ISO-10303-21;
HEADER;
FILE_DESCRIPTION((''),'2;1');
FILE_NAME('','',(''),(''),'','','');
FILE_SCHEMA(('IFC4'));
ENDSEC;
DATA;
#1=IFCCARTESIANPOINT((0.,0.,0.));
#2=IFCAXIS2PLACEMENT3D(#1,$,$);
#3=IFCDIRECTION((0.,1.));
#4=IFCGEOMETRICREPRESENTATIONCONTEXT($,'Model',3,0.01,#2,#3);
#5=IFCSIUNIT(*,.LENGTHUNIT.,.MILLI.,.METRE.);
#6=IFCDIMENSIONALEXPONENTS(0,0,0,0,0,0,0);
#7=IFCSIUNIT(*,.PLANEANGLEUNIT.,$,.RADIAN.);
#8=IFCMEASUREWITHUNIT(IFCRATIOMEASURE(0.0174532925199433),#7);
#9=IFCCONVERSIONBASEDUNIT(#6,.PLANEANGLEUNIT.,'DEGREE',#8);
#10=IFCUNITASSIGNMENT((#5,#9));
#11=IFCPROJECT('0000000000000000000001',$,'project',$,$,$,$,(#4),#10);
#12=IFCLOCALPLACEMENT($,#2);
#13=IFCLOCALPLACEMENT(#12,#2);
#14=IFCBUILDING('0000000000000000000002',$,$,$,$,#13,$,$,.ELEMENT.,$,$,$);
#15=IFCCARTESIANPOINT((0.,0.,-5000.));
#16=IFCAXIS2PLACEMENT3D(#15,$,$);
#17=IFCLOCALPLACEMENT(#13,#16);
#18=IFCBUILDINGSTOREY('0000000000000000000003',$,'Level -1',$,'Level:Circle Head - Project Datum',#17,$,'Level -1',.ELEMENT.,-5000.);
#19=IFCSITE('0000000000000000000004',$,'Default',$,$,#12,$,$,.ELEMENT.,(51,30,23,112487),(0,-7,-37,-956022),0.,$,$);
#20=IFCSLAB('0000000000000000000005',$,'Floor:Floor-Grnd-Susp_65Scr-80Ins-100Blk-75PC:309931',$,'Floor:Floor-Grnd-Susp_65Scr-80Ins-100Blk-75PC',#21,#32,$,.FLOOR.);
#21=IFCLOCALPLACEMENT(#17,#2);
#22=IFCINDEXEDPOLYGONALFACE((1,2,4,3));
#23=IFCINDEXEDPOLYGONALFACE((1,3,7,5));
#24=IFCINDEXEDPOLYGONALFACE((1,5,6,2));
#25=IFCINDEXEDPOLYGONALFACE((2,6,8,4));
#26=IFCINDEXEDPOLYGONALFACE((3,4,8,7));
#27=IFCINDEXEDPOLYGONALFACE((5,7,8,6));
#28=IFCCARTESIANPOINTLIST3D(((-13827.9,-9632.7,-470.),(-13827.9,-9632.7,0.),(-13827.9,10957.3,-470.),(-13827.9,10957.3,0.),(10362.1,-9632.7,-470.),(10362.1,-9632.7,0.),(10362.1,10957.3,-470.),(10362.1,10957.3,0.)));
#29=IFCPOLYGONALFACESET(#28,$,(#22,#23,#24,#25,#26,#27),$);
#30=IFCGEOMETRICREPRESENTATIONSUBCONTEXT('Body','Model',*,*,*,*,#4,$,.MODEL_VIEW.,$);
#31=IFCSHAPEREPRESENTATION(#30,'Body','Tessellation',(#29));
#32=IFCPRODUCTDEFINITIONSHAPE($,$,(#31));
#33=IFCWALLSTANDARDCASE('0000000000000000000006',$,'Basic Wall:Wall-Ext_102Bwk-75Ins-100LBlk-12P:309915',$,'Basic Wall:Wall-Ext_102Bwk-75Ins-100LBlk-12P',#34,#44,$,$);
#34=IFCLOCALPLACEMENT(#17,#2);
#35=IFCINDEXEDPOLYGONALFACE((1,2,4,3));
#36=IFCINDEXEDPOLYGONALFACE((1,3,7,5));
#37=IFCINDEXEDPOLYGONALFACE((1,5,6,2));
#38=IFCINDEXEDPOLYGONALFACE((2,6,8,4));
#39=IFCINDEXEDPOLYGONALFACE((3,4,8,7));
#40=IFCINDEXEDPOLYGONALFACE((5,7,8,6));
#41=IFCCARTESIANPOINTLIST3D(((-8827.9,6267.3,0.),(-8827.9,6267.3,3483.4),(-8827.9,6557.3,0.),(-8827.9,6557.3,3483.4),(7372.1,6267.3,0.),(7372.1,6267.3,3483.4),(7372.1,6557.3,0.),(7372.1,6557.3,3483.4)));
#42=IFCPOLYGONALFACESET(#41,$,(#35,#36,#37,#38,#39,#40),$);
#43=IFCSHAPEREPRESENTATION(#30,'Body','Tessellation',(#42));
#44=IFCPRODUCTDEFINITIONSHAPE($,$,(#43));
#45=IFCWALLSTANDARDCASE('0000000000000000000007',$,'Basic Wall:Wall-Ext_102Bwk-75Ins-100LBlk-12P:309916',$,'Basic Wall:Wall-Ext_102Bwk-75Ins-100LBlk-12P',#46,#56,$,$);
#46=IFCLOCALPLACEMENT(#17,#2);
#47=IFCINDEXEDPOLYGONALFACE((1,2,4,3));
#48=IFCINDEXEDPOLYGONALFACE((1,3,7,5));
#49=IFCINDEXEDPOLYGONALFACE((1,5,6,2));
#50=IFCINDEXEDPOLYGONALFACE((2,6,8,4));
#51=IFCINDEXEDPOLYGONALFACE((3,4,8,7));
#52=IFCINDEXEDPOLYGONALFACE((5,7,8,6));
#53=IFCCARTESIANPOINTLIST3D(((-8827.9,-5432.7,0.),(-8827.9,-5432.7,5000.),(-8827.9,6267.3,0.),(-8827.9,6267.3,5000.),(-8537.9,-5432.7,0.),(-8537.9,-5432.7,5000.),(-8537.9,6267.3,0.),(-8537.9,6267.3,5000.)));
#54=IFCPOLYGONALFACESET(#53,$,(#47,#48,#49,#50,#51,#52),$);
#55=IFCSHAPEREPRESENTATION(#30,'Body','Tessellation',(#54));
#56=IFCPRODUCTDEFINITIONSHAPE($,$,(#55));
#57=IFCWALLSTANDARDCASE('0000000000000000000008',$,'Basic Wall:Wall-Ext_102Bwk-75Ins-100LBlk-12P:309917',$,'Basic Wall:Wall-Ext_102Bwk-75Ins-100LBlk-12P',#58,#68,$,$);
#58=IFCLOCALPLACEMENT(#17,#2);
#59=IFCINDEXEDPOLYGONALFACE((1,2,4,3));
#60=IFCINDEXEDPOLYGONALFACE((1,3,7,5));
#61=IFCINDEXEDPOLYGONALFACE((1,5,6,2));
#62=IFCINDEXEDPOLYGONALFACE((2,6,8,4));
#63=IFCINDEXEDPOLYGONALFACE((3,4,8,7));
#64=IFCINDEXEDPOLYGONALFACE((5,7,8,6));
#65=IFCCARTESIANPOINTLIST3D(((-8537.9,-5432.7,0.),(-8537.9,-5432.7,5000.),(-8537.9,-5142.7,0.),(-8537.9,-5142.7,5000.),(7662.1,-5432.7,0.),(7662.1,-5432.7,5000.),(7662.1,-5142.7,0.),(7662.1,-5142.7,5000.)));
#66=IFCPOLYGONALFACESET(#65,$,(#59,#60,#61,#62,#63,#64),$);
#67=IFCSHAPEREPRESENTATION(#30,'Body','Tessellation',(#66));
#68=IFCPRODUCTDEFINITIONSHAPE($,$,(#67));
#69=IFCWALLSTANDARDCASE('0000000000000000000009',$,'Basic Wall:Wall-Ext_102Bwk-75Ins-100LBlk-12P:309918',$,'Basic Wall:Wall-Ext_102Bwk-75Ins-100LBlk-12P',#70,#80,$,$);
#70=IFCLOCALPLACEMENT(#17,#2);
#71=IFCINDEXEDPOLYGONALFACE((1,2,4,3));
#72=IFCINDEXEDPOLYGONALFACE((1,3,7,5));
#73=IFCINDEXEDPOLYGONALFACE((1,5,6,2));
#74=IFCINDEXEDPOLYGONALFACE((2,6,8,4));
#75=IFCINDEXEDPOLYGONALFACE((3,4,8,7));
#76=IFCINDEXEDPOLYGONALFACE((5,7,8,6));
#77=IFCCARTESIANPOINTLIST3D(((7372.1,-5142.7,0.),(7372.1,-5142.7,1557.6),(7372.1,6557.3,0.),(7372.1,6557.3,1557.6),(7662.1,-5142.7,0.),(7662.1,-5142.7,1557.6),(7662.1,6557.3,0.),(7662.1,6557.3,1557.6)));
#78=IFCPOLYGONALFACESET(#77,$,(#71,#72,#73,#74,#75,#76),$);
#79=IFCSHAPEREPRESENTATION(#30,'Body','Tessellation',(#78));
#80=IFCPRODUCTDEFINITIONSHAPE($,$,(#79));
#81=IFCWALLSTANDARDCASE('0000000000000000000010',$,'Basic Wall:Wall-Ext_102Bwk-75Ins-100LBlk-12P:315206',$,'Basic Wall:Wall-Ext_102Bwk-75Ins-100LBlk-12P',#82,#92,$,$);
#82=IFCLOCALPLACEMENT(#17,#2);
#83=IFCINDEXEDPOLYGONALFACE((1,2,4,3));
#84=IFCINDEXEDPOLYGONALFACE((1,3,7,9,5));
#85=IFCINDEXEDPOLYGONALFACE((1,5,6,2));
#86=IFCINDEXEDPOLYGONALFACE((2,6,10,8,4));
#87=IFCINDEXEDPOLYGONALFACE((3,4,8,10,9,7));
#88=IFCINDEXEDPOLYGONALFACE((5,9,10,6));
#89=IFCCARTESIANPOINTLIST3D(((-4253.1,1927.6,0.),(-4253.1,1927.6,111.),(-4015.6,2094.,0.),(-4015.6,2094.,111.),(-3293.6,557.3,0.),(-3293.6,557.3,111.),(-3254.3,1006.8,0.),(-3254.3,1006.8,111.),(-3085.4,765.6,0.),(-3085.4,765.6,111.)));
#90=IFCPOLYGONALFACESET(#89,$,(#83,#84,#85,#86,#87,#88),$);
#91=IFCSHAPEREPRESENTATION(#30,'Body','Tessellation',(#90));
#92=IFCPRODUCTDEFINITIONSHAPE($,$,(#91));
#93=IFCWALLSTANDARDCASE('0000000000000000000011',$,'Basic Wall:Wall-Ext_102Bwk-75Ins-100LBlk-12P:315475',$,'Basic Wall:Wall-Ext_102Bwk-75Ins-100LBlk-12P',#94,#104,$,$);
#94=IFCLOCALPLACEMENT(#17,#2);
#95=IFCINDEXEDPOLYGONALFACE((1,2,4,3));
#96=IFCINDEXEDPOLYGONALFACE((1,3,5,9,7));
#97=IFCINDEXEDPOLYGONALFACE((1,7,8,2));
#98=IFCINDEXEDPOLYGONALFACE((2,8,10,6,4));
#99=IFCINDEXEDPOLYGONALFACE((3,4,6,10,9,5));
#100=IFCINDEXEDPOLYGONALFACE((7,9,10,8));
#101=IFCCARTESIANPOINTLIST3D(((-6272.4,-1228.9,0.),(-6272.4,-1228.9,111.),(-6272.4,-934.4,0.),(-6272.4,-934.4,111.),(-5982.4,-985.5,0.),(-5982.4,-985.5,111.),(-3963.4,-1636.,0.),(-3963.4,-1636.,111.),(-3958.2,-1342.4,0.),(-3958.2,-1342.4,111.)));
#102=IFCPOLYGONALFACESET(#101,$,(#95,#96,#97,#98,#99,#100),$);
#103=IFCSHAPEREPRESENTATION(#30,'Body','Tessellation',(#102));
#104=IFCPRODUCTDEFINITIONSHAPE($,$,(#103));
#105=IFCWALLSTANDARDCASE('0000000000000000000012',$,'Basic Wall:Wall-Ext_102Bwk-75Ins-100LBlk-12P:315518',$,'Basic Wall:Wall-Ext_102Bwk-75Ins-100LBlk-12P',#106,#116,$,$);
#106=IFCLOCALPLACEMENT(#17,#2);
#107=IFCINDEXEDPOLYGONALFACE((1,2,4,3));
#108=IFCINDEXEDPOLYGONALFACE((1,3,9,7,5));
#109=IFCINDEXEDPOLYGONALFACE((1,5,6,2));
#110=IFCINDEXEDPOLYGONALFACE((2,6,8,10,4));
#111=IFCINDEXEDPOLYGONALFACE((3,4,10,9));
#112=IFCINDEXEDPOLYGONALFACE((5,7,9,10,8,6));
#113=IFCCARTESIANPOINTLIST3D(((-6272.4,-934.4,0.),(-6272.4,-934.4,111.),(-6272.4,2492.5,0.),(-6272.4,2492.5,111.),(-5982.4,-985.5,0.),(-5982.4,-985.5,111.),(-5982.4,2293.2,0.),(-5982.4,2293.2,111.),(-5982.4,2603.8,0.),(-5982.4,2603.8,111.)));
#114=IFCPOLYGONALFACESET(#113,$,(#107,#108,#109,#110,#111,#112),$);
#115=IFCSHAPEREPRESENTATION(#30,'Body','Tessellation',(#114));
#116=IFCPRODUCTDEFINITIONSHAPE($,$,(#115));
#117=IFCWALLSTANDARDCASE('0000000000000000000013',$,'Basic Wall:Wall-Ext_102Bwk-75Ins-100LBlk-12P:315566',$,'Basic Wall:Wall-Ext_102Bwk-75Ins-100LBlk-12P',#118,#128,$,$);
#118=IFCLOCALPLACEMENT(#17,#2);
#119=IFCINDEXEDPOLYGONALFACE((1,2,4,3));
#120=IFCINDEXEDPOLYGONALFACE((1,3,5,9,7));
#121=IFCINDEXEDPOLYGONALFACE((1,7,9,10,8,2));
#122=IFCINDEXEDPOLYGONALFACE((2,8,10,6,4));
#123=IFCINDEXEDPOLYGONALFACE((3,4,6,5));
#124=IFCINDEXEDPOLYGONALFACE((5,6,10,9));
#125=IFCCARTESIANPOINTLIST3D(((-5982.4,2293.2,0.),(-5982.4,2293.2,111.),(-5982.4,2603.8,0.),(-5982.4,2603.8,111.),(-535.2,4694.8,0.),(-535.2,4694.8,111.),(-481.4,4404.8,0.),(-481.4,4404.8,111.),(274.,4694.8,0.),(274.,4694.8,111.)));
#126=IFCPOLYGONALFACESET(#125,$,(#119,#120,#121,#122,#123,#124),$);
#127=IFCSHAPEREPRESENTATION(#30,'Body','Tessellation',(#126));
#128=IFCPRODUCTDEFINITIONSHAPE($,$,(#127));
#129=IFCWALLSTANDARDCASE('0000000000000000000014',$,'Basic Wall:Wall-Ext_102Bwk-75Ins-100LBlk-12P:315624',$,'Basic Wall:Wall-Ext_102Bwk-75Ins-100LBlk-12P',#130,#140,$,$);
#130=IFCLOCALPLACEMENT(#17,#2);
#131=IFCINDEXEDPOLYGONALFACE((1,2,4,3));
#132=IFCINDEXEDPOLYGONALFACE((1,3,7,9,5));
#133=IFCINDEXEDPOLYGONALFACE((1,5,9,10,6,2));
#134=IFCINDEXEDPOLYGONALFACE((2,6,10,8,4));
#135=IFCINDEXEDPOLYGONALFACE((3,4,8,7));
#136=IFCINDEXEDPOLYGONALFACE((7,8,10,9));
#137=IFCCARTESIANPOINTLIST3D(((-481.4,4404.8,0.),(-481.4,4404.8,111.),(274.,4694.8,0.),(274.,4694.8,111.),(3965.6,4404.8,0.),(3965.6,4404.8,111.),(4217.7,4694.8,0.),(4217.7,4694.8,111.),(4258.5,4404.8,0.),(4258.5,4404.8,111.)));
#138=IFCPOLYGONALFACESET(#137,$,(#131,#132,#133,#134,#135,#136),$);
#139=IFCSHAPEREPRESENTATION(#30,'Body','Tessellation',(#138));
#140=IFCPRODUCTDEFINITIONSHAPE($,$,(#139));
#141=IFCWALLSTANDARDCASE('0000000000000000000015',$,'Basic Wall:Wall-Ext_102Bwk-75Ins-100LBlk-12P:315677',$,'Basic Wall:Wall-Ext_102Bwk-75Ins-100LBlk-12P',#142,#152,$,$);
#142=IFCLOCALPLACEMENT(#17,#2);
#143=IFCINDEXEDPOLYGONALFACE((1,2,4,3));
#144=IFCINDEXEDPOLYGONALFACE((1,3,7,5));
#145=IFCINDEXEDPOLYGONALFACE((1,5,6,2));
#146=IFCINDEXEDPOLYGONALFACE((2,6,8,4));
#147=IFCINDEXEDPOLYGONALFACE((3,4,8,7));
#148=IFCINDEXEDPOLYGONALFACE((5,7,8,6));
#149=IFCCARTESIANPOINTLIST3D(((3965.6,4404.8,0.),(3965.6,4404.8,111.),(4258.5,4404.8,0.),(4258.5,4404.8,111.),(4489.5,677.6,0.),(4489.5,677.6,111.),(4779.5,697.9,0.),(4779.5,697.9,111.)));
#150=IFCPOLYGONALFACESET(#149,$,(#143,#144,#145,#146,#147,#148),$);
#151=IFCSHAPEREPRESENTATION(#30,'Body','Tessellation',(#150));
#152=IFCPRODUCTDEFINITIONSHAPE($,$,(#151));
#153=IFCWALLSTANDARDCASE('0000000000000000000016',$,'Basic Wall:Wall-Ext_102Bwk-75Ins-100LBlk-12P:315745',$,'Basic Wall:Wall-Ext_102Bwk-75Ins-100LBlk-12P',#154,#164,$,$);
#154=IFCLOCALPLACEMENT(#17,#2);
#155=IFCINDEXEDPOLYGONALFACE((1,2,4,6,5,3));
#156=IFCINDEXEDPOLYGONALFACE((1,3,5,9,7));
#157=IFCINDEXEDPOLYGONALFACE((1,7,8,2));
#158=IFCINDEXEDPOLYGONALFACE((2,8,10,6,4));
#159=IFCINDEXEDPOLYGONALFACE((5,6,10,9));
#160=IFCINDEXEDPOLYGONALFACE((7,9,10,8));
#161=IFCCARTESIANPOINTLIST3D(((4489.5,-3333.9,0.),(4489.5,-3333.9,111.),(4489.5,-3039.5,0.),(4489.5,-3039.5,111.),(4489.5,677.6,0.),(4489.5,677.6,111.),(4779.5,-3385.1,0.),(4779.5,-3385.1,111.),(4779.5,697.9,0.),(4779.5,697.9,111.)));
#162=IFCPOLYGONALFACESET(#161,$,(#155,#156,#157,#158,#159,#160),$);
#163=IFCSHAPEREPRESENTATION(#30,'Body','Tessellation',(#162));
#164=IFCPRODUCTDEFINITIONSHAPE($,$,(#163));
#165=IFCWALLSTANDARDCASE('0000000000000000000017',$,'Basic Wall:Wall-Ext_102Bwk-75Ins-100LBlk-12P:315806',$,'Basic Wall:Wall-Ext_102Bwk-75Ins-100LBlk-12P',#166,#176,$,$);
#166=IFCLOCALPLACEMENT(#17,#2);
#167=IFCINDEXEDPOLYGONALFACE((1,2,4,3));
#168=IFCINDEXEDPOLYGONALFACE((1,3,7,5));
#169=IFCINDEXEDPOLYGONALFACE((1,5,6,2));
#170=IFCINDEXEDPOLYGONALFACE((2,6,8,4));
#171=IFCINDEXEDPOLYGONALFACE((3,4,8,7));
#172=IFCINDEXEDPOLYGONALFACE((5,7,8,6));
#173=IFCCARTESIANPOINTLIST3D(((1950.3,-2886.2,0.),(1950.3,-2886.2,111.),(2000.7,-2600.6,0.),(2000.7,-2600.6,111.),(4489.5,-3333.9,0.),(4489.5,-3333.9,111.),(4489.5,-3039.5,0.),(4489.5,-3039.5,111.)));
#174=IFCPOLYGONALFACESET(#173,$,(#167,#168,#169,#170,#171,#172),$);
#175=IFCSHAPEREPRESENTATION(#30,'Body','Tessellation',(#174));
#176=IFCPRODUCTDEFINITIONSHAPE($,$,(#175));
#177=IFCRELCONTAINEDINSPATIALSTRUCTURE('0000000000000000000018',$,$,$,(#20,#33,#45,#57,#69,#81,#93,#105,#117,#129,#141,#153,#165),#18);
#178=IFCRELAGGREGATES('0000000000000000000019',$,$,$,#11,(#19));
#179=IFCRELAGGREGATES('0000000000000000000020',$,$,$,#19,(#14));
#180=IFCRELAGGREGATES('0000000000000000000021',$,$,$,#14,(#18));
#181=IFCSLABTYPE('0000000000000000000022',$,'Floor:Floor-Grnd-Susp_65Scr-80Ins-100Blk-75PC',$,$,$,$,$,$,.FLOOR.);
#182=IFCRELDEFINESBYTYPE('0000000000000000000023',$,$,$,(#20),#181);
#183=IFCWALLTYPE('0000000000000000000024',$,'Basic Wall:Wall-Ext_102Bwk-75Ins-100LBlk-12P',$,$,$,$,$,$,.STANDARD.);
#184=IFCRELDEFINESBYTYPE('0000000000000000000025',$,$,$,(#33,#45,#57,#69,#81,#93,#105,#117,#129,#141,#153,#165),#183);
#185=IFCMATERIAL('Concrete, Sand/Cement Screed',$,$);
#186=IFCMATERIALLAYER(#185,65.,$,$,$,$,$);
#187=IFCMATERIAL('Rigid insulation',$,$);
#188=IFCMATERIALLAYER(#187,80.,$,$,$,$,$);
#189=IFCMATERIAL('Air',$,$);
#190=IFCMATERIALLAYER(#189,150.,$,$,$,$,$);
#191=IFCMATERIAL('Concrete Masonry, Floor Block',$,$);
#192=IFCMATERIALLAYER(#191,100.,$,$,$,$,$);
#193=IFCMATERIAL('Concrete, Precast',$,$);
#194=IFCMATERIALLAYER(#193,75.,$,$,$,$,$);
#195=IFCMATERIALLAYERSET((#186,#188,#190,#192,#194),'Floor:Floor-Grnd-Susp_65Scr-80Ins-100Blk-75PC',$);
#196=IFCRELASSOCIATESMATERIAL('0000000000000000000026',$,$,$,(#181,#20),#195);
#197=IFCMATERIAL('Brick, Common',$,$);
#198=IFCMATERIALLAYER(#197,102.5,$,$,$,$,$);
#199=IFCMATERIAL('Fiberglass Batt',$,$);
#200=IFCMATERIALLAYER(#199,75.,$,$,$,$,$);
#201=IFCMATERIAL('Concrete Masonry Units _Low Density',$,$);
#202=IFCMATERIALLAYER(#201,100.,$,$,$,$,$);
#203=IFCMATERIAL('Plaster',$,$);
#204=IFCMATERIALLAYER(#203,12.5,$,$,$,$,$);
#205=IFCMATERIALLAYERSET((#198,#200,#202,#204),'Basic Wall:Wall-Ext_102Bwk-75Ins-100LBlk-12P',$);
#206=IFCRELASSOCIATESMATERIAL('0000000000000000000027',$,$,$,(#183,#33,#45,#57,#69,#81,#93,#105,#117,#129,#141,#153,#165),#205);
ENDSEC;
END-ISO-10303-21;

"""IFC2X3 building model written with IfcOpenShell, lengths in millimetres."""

from ifc_helpers import new_model, entity, si_unit, converted_unit, direction, frame, frame_2d, origin, origin_2d_with_axis, place, context, subcontext, project, spatial, polyline, rectangle, outline, extrude, material, layer, layer_set, layer_usage, type_object, element, save


model = new_model("IFC2X3")

# Units and contexts
model_context = context("Model", 3, precision=0.01, world=origin(), true_north=direction((0.0, 1.0)))
body_context = subcontext(model_context, "Body", "Model", "MODEL_VIEW")
ifc_project = project(units=[si_unit("LENGTHUNIT", "METRE", prefix="MILLI"), converted_unit("PLANEANGLEUNIT", "DEGREE", entity("IfcRatioMeasure", 0.0174532925199433), si_unit("PLANEANGLEUNIT", "RADIAN"), dimensions=[0, 0, 0, 0, 0, 0, 0])], contexts=[model_context])

# Site, building, storey
site_placement = place(None, origin())
site = spatial("IfcSite", under=ifc_project, at=site_placement, Name="Default", CompositionType="ELEMENT", RefLatitude=(51, 30, 23, 112487), RefLongitude=(0, -7, -37, -956022), RefElevation=0.0)
building_placement = place(site_placement, origin())
building = spatial("IfcBuilding", under=site, at=building_placement, CompositionType="ELEMENT")
storey_placement = place(building_placement, frame((0.0, 0.0, -5000.0)))
storey = spatial("IfcBuildingStorey", under=building, at=storey_placement, Name="Level -1", ObjectType="Level:Circle Head - Project Datum", LongName="Level -1", CompositionType="ELEMENT", Elevation=-5000.0)

# Slab
ifc_material_1 = material(Name="Concrete, Sand/Cement Screed")
ifc_layer_1 = layer(ifc_material_1, 65.0)
ifc_material_2 = material(Name="Rigid insulation")
ifc_layer_2 = layer(ifc_material_2, 80.0)
ifc_material_3 = material(Name="Air")
ifc_layer_3 = layer(ifc_material_3, 150.0)
ifc_material_4 = material(Name="Concrete Masonry, Floor Block")
ifc_layer_4 = layer(ifc_material_4, 100.0)
ifc_material_5 = material(Name="Concrete, Precast")
ifc_layer_5 = layer(ifc_material_5, 75.0)
ifc_layer_set_1 = layer_set([ifc_layer_1, ifc_layer_2, ifc_layer_3, ifc_layer_4, ifc_layer_5], Name="Floor:Floor-Grnd-Susp_65Scr-80Ins-100Blk-75PC")
ifc_layer_usage_1 = layer_usage(ifc_layer_set_1, "AXIS3", "POSITIVE", 0.0)
slab_type = type_object("IfcSlabType", Name="Floor:Floor-Grnd-Susp_65Scr-80Ins-100Blk-75PC", PredefinedType="FLOOR", material=ifc_layer_set_1)
slab_placement = place(storey_placement, origin())
element("IfcSlab", 1, at=slab_placement, inside=storey, type_object=slab_type, material=ifc_layer_usage_1, Name="Floor:Floor-Grnd-Susp_65Scr-80Ins-100Blk-75PC:309931", ObjectType="Floor:Floor-Grnd-Susp_65Scr-80Ins-100Blk-75PC", PredefinedType="FLOOR", context=body_context, shape_type="SweptSolid", body=[
    extrude(rectangle(XDim=20590.0, YDim=24190.0, at=origin_2d_with_axis()), frame((-1732.9, 662.3, 0.0), z_axis=(0.0, 0.0, -1.0), x_axis=(0.0, 1.0, 0.0)), (0.0, 0.0, 1.0), 470.0),
])

# Walls
ifc_material_6 = material(Name="Brick, Common")
ifc_layer_6 = layer(ifc_material_6, 102.5)
ifc_material_7 = material(Name="Fiberglass Batt")
ifc_layer_7 = layer(ifc_material_7, 75.0)
ifc_material_8 = material(Name="Concrete Masonry Units _Low Density")
ifc_layer_8 = layer(ifc_material_8, 100.0)
ifc_material_9 = material(Name="Plaster")
ifc_layer_9 = layer(ifc_material_9, 12.5)
ifc_layer_set_2 = layer_set([ifc_layer_6, ifc_layer_7, ifc_layer_8, ifc_layer_9], Name="Basic Wall:Wall-Ext_102Bwk-75Ins-100LBlk-12P")
ifc_layer_usage_2 = layer_usage(ifc_layer_set_2, "AXIS2", "NEGATIVE", 145.0)
wall_type = type_object("IfcWallType", Name="Basic Wall:Wall-Ext_102Bwk-75Ins-100LBlk-12P", PredefinedType="STANDARD", material=ifc_layer_set_2)
wall_1_placement = place(storey_placement, frame((-8827.9, 6412.3, 0.0)))
element("IfcWallStandardCase", 2, at=wall_1_placement, inside=storey, type_object=wall_type, material=ifc_layer_usage_2, Name="Basic Wall:Wall-Ext_102Bwk-75Ins-100LBlk-12P:309915", ObjectType="Basic Wall:Wall-Ext_102Bwk-75Ins-100LBlk-12P", context=body_context, shape_type="SweptSolid", body=[
    extrude(rectangle(XDim=16200.0, YDim=290.0, at=frame_2d((8100.0, 0.0), x_axis=(-1.0, 0.0))), origin(), (0.0, 0.0, 1.0), 3483.4),
])
ifc_layer_usage_3 = layer_usage(ifc_layer_set_2, "AXIS2", "NEGATIVE", 145.0)
wall_2_placement = place(storey_placement, frame((-8682.9, -5432.7, 0.0), z_axis=(0.0, 0.0, 1.0), x_axis=(0.0, 1.0, 0.0)))
element("IfcWallStandardCase", 3, at=wall_2_placement, inside=storey, type_object=wall_type, material=ifc_layer_usage_3, Name="Basic Wall:Wall-Ext_102Bwk-75Ins-100LBlk-12P:309916", ObjectType="Basic Wall:Wall-Ext_102Bwk-75Ins-100LBlk-12P", context=body_context, shape_type="SweptSolid", body=[
    extrude(rectangle(XDim=11700.0, YDim=290.0, at=frame_2d((5850.0, 0.0), x_axis=(-1.0, 0.0))), origin(), (0.0, 0.0, 1.0), 5000.0),
])
ifc_layer_usage_4 = layer_usage(ifc_layer_set_2, "AXIS2", "NEGATIVE", 145.0)
wall_3_placement = place(storey_placement, frame((7662.1, -5287.7, 0.0), z_axis=(0.0, 0.0, 1.0), x_axis=(-1.0, 0.0, 0.0)))
element("IfcWallStandardCase", 4, at=wall_3_placement, inside=storey, type_object=wall_type, material=ifc_layer_usage_4, Name="Basic Wall:Wall-Ext_102Bwk-75Ins-100LBlk-12P:309917", ObjectType="Basic Wall:Wall-Ext_102Bwk-75Ins-100LBlk-12P", context=body_context, shape_type="SweptSolid", body=[
    extrude(rectangle(XDim=16200.0, YDim=290.0, at=frame_2d((8100.0, 0.0), x_axis=(-1.0, 0.0))), origin(), (0.0, 0.0, 1.0), 5000.0),
])
ifc_layer_usage_5 = layer_usage(ifc_layer_set_2, "AXIS2", "NEGATIVE", 145.0)
wall_4_placement = place(storey_placement, frame((7517.1, 6557.3, 0.0), z_axis=(0.0, 0.0, 1.0), x_axis=(0.0, -1.0, 0.0)))
element("IfcWallStandardCase", 5, at=wall_4_placement, inside=storey, type_object=wall_type, material=ifc_layer_usage_5, Name="Basic Wall:Wall-Ext_102Bwk-75Ins-100LBlk-12P:309918", ObjectType="Basic Wall:Wall-Ext_102Bwk-75Ins-100LBlk-12P", context=body_context, shape_type="SweptSolid", body=[
    extrude(rectangle(XDim=11700.0, YDim=290.0, at=frame_2d((5850.0, 0.0), x_axis=(-1.0, 0.0))), origin(), (0.0, 0.0, 1.0), 1557.6),
])
ifc_layer_usage_6 = layer_usage(ifc_layer_set_2, "AXIS2", "NEGATIVE", 145.0)
wall_5_placement = place(storey_placement, frame((-4134.4, 2010.8, 0.0), z_axis=(0.0, 0.0, 1.0), x_axis=(0.573576, -0.819152, 0.0)))
element("IfcWallStandardCase", 6, at=wall_5_placement, inside=storey, type_object=wall_type, material=ifc_layer_usage_6, Name="Basic Wall:Wall-Ext_102Bwk-75Ins-100LBlk-12P:315206", ObjectType="Basic Wall:Wall-Ext_102Bwk-75Ins-100LBlk-12P", context=body_context, shape_type="SweptSolid", body=[
    extrude(outline(polyline([(1672.8, -145.0), (1621.7, 145.0), (1327.2, 145.0), (0.0, 145.0), (0.0, -145.0), (1672.8, -145.0)])), origin(), (0.0, 0.0, 1.0), 111.0),
])
ifc_layer_usage_7 = layer_usage(ifc_layer_set_2, "AXIS2", "NEGATIVE", 145.0)
wall_6_placement = place(storey_placement, frame((-3938.2, -1493.2, 0.0), z_axis=(0.0, 0.0, 1.0), x_axis=(-0.984808, 0.173648, 0.0)))
element("IfcWallStandardCase", 7, at=wall_6_placement, inside=storey, type_object=wall_type, material=ifc_layer_usage_7, Name="Basic Wall:Wall-Ext_102Bwk-75Ins-100LBlk-12P:315475", ObjectType="Basic Wall:Wall-Ext_102Bwk-75Ins-100LBlk-12P", context=body_context, shape_type="SweptSolid", body=[
    extrude(outline(polyline([(2395.8, -145.0), (2344.6, 145.0), (0.0, 145.0), (45.9, -145.0), (2101.3, -145.0), (2395.8, -145.0)])), origin(), (0.0, 0.0, 1.0), 111.0),
])
ifc_layer_usage_8 = layer_usage(ifc_layer_set_2, "AXIS2", "NEGATIVE", 145.0)
wall_7_placement = place(storey_placement, frame((-6127.4, -985.5, 0.0), z_axis=(0.0, 0.0, 1.0), x_axis=(0.0, 1.0, 0.0)))
element("IfcWallStandardCase", 8, at=wall_7_placement, inside=storey, type_object=wall_type, material=ifc_layer_usage_8, Name="Basic Wall:Wall-Ext_102Bwk-75Ins-100LBlk-12P:315518", ObjectType="Basic Wall:Wall-Ext_102Bwk-75Ins-100LBlk-12P", context=body_context, shape_type="SweptSolid", body=[
    extrude(outline(polyline([(3589.3, -145.0), (3478.0, 145.0), (51.1, 145.0), (0.0, -145.0), (3278.7, -145.0), (3589.3, -145.0)])), origin(), (0.0, 0.0, 1.0), 111.0),
])
ifc_layer_usage_9 = layer_usage(ifc_layer_set_2, "AXIS2", "NEGATIVE", 145.0)
wall_8_placement = place(storey_placement, frame((-6034.3, 2428.5, 0.0), z_axis=(0.0, 0.0, 1.0), x_axis=(0.93358, 0.358368, 0.0)))
element("IfcWallStandardCase", 9, at=wall_8_placement, inside=storey, type_object=wall_type, material=ifc_layer_usage_9, Name="Basic Wall:Wall-Ext_102Bwk-75Ins-100LBlk-12P:315566", ObjectType="Basic Wall:Wall-Ext_102Bwk-75Ins-100LBlk-12P", context=body_context, shape_type="SweptSolid", body=[
    extrude(outline(polyline([(6701.5, -145.0), (5946.0, 145.0), (111.3, 145.0), (0.0, -145.0), (5892.3, -145.0), (6701.5, -145.0)])), origin(), (0.0, 0.0, 1.0), 111.0),
])
ifc_layer_usage_10 = layer_usage(ifc_layer_set_2, "AXIS2", "NEGATIVE", 145.0)
wall_9_placement = place(storey_placement, frame((-481.4, 4549.8, 0.0)))
element("IfcWallStandardCase", 10, at=wall_9_placement, inside=storey, type_object=wall_type, material=ifc_layer_usage_10, Name="Basic Wall:Wall-Ext_102Bwk-75Ins-100LBlk-12P:315624", ObjectType="Basic Wall:Wall-Ext_102Bwk-75Ins-100LBlk-12P", context=body_context, shape_type="SweptSolid", body=[
    extrude(outline(polyline([(4739.9, -145.0), (4699.2, 145.0), (755.5, 145.0), (0.0, -145.0), (4447.1, -145.0), (4739.9, -145.0)])), origin(), (0.0, 0.0, 1.0), 111.0),
])
ifc_layer_usage_11 = layer_usage(ifc_layer_set_2, "AXIS2", "NEGATIVE", 145.0)
wall_10_placement = place(storey_placement, frame((4109.2, 4424.9, 0.0), z_axis=(0.0, 0.0, 1.0), x_axis=(0.139173, -0.990268, 0.0)))
element("IfcWallStandardCase", 11, at=wall_10_placement, inside=storey, type_object=wall_type, material=ifc_layer_usage_11, Name="Basic Wall:Wall-Ext_102Bwk-75Ins-100LBlk-12P:315677", ObjectType="Basic Wall:Wall-Ext_102Bwk-75Ins-100LBlk-12P", context=body_context, shape_type="SweptSolid", body=[
    extrude(outline(polyline([(3763.8, -145.0), (3784.1, 145.0), (40.8, 145.0), (0.0, -145.0), (3763.8, -145.0)])), origin(), (0.0, 0.0, 1.0), 111.0),
])
ifc_layer_usage_12 = layer_usage(ifc_layer_set_2, "AXIS2", "NEGATIVE", 145.0)
wall_11_placement = place(storey_placement, frame((4634.5, 697.9, 0.0), z_axis=(0.0, 0.0, 1.0), x_axis=(0.0, -1.0, 0.0)))
element("IfcWallStandardCase", 12, at=wall_11_placement, inside=storey, type_object=wall_type, material=ifc_layer_usage_12, Name="Basic Wall:Wall-Ext_102Bwk-75Ins-100LBlk-12P:315745", ObjectType="Basic Wall:Wall-Ext_102Bwk-75Ins-100LBlk-12P", context=body_context, shape_type="SweptSolid", body=[
    extrude(outline(polyline([(4031.8, -145.0), (4082.9, 145.0), (0.0, 145.0), (20.3, -145.0), (3737.3, -145.0), (4031.8, -145.0)])), origin(), (0.0, 0.0, 1.0), 111.0),
])
ifc_layer_usage_13 = layer_usage(ifc_layer_set_2, "AXIS2", "NEGATIVE", 145.0)
wall_12_placement = place(storey_placement, frame((4514.6, -3191.2, 0.0), z_axis=(0.0, 0.0, 1.0), x_axis=(-0.984808, 0.173648, 0.0)))
element("IfcWallStandardCase", 13, at=wall_12_placement, inside=storey, type_object=wall_type, material=ifc_layer_usage_13, Name="Basic Wall:Wall-Ext_102Bwk-75Ins-100LBlk-12P:315806", ObjectType="Basic Wall:Wall-Ext_102Bwk-75Ins-100LBlk-12P", context=body_context, shape_type="SweptSolid", body=[
    extrude(outline(polyline([(2578.3, -145.0), (2578.3, 145.0), (0.0, 145.0), (51.1, -145.0), (2578.3, -145.0)])), origin(), (0.0, 0.0, 1.0), 111.0),
])

save(model, "model.ifc")
